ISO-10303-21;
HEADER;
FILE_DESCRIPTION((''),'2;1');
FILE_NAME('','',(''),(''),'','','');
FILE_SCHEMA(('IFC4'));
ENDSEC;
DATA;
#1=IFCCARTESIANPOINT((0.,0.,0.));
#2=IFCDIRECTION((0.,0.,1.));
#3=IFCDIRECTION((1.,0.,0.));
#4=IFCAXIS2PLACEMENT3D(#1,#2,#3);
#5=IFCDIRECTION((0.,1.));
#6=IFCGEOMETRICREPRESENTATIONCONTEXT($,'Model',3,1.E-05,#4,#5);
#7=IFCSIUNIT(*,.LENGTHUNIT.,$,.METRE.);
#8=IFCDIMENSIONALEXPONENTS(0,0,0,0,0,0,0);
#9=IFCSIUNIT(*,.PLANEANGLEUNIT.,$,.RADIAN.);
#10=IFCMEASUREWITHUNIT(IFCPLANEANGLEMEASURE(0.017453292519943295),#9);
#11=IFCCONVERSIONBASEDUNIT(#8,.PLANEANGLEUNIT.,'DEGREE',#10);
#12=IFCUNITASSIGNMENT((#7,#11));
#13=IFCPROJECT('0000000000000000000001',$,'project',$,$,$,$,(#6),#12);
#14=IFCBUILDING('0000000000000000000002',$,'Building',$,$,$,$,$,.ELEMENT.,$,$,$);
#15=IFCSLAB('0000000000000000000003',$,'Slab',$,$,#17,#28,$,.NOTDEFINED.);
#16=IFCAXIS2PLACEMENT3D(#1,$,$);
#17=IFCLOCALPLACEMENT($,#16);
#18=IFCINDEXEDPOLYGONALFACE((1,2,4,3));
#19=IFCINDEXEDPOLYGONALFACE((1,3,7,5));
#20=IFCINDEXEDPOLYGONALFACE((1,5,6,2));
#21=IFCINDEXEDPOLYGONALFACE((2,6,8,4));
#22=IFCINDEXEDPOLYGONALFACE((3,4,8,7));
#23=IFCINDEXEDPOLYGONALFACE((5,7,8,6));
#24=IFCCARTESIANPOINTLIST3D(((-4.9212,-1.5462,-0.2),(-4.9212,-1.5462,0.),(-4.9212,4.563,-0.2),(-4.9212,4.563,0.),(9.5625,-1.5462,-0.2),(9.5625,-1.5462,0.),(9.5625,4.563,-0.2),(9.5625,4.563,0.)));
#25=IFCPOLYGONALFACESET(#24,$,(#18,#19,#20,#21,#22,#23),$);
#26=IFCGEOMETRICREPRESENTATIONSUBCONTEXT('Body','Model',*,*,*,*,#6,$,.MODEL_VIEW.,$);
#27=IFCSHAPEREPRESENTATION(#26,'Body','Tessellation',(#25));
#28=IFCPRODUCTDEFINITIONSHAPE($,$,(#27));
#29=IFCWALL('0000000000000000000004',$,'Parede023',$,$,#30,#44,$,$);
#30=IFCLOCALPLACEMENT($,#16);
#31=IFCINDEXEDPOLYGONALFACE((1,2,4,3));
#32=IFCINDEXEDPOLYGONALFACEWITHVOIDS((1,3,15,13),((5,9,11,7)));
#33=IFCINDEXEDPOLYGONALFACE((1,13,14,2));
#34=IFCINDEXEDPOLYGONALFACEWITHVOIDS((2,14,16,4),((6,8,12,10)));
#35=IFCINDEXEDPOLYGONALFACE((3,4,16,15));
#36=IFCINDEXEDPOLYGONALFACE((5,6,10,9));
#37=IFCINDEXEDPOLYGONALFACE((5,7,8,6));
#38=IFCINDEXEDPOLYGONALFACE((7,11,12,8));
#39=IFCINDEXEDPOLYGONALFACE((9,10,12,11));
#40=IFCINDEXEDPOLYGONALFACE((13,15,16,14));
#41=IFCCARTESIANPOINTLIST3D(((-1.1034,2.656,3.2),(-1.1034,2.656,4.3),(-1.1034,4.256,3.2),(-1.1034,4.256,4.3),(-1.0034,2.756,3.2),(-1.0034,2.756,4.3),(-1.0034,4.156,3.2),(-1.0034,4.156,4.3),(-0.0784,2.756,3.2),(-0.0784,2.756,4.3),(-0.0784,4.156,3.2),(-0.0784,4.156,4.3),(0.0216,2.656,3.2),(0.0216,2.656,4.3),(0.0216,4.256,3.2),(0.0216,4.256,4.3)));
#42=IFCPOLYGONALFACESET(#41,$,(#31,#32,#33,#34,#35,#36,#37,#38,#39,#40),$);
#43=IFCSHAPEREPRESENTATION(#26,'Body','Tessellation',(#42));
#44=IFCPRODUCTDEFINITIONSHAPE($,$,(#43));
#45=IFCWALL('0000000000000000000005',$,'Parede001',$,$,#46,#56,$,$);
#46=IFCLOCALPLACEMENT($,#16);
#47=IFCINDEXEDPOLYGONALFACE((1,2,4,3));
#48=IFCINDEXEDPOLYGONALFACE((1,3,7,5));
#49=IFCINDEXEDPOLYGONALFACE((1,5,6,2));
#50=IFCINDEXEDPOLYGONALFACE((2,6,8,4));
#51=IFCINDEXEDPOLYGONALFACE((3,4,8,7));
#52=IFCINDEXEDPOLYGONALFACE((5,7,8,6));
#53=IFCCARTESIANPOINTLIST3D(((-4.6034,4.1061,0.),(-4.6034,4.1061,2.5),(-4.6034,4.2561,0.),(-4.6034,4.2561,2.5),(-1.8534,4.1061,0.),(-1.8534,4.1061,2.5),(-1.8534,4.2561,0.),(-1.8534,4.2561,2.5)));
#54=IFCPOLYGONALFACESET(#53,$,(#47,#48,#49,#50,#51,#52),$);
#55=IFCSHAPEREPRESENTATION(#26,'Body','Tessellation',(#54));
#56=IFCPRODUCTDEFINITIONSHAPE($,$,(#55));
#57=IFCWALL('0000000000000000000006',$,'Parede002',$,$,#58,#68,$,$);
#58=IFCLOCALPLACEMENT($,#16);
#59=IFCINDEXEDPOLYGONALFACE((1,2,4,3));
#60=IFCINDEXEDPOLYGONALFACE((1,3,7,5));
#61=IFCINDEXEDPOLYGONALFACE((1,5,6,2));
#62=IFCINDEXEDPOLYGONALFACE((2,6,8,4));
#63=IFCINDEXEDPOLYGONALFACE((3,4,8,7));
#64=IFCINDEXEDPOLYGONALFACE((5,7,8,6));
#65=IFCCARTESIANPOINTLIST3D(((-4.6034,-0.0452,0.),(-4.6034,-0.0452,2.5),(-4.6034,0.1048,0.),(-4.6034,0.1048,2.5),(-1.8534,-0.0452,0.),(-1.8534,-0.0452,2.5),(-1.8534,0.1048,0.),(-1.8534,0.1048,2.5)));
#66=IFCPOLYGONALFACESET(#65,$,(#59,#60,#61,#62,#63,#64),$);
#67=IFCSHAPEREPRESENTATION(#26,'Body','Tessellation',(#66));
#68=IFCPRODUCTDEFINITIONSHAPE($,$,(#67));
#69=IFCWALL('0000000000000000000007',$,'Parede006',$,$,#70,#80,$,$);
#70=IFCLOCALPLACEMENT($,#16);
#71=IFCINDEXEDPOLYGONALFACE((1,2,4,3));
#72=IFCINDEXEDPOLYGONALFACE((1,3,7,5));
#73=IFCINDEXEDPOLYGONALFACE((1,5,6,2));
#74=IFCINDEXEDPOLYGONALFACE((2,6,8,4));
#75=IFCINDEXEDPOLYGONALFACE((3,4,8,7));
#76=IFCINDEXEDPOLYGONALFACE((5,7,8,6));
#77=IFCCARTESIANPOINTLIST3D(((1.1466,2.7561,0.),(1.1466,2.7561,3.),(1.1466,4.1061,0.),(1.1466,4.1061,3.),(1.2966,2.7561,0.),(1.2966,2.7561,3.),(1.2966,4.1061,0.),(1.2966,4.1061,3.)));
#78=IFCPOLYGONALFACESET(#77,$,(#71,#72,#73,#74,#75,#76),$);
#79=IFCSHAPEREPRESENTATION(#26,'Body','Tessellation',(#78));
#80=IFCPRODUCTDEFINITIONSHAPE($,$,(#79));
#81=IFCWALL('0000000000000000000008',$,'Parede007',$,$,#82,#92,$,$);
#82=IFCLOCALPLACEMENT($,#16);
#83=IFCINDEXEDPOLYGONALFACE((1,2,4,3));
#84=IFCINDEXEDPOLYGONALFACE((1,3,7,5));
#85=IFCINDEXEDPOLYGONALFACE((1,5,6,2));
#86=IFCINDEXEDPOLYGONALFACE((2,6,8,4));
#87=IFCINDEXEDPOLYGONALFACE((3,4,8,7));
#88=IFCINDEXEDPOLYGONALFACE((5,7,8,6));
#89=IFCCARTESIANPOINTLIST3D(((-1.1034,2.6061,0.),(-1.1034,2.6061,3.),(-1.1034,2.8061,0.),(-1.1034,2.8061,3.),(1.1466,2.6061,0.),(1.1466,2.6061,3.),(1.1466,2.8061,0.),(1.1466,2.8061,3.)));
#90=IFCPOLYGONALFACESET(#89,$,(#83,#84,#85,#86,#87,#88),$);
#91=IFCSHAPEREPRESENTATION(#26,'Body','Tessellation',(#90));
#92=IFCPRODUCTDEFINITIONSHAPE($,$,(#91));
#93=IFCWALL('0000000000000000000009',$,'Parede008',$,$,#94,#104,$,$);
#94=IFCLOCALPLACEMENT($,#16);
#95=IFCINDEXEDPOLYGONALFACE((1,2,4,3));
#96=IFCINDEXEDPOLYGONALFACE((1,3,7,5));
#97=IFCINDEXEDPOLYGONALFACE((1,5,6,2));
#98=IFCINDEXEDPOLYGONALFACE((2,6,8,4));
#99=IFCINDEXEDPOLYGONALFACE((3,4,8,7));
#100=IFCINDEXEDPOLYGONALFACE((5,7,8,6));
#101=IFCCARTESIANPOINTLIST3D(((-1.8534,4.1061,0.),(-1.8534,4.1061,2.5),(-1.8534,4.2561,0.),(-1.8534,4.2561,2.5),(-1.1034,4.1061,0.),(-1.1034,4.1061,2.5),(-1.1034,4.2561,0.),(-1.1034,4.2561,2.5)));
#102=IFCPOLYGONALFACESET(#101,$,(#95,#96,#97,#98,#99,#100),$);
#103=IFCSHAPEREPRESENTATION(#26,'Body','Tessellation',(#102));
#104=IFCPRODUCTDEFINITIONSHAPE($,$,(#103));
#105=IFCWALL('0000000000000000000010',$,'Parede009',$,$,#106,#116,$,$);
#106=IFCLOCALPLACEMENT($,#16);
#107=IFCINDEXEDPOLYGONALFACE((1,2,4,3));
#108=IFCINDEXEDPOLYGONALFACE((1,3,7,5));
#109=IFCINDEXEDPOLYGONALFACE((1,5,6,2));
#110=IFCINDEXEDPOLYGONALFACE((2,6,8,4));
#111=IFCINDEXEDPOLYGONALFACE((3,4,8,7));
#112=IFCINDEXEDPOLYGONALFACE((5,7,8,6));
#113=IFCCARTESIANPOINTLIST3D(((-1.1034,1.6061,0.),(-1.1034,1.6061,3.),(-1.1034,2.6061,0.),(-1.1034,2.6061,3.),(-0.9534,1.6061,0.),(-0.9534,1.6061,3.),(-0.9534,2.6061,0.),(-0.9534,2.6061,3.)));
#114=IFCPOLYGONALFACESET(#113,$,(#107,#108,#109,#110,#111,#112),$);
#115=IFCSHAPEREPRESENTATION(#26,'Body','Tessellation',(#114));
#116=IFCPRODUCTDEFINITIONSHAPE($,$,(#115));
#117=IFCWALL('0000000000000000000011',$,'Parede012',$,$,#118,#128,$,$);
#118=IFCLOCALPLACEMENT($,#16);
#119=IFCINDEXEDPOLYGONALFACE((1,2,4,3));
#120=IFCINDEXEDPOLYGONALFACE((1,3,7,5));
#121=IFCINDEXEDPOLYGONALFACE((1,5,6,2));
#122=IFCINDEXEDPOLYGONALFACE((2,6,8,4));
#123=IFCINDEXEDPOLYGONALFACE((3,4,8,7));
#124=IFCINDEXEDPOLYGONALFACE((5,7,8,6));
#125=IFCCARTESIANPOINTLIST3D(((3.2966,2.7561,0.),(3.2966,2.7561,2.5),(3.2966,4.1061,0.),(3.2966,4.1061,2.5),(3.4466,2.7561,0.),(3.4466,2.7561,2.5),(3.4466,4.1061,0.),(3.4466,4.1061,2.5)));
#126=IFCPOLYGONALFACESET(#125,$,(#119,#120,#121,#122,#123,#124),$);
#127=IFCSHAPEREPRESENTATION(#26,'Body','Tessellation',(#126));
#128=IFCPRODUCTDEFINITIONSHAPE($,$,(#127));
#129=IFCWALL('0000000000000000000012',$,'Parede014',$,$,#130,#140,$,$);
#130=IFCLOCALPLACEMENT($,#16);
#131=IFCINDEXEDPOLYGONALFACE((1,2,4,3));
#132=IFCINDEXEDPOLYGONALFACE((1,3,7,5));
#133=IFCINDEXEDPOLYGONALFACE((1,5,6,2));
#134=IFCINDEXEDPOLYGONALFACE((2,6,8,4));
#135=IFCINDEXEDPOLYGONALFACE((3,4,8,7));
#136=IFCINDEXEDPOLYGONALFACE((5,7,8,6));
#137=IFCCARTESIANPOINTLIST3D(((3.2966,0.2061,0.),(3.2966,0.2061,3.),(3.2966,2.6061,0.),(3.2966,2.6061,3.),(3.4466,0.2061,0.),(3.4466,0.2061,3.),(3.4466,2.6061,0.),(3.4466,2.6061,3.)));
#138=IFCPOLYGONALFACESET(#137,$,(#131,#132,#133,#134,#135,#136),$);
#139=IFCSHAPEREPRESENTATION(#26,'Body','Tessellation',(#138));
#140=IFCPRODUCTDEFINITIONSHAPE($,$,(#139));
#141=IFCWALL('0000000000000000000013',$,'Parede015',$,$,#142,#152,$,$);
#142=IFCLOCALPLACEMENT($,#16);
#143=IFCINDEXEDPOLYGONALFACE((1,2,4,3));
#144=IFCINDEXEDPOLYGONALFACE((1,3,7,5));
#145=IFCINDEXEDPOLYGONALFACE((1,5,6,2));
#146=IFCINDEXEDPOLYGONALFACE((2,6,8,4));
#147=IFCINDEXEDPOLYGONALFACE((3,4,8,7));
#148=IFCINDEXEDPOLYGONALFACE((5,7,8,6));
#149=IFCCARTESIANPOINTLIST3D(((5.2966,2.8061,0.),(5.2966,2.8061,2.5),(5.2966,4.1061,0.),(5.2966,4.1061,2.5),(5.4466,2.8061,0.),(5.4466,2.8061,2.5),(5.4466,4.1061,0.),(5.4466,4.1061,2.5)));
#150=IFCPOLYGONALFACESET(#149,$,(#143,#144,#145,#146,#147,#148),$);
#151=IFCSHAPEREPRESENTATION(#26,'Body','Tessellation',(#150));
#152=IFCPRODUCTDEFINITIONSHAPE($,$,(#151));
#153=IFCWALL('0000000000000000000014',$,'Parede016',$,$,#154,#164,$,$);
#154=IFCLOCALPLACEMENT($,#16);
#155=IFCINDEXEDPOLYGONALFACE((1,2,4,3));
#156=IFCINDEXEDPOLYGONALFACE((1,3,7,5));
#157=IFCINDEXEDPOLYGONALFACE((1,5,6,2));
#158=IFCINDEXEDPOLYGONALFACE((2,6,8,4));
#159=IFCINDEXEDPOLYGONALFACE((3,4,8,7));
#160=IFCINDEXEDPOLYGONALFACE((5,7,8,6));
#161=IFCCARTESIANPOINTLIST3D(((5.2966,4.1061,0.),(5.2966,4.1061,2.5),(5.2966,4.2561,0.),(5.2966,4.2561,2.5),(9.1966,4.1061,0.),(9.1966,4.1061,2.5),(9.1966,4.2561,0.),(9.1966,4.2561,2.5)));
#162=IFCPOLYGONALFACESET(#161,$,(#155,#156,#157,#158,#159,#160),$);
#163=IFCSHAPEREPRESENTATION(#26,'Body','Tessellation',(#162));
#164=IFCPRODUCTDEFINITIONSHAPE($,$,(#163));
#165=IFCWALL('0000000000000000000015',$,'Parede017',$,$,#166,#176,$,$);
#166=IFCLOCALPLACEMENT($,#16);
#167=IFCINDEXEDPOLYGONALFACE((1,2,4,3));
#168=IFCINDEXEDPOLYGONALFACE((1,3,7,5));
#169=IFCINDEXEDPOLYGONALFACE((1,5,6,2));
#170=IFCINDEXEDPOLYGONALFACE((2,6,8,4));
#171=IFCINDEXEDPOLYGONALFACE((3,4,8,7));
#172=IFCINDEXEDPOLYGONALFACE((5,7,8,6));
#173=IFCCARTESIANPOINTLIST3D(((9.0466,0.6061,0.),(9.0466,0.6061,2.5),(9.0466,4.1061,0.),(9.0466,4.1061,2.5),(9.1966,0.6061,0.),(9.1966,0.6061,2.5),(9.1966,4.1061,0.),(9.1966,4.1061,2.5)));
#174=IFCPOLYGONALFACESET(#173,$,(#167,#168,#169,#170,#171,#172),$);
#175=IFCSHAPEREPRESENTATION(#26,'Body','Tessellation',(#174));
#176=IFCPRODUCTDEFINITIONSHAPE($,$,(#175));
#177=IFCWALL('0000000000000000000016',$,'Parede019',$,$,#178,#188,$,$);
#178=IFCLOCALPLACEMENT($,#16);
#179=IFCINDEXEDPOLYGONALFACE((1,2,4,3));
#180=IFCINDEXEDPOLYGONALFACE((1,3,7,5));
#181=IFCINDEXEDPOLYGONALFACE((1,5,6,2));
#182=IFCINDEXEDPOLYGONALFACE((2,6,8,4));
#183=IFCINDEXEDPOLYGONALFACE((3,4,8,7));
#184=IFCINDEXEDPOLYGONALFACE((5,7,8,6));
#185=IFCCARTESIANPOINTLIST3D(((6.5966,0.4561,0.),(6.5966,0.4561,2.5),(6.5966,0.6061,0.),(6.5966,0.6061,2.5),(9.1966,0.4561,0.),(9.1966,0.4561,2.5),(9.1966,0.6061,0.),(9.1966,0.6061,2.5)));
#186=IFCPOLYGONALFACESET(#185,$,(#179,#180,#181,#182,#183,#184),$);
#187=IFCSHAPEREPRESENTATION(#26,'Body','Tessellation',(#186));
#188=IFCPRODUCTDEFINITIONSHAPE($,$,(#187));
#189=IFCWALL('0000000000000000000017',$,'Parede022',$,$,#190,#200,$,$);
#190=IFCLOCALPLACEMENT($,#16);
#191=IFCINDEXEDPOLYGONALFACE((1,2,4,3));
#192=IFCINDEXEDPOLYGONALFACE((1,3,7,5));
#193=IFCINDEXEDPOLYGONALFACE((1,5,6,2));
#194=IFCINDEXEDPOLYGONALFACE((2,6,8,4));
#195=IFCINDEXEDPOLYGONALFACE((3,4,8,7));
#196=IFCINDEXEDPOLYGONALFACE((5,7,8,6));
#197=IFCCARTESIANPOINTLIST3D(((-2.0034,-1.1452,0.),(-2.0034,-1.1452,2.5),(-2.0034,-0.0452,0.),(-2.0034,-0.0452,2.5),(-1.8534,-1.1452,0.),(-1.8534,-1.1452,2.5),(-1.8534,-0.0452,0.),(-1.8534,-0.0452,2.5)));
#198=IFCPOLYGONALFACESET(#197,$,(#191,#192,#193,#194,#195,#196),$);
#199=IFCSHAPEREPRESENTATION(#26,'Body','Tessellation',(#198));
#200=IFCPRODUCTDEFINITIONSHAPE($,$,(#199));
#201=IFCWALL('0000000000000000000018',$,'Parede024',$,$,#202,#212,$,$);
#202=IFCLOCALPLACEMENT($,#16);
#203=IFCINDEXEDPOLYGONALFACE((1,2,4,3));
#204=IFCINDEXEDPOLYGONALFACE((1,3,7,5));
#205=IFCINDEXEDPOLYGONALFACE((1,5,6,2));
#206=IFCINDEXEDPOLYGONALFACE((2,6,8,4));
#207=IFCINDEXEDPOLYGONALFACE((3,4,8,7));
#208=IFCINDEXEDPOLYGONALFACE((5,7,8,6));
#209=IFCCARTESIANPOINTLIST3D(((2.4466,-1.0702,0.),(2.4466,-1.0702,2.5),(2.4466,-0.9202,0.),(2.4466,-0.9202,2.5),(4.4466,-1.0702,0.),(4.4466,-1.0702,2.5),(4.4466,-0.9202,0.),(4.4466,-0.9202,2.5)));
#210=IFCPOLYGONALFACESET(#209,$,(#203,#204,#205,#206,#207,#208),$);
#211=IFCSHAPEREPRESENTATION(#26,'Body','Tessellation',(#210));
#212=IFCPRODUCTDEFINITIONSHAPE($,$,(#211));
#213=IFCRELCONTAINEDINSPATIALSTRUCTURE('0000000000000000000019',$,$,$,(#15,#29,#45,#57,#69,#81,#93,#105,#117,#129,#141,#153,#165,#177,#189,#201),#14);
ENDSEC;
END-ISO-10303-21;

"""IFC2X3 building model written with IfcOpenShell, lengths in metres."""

from ifc_helpers import new_model, entity, si_unit, converted_unit, direction, frame, frame_2d, origin_with_axes, origin_2d_with_axis, place, context, subcontext, project, spatial, polyline, rectangle, outline, extrude, element, save


model = new_model("IFC2X3")

# Units and contexts
model_context = context("Model", 3, precision=1e-05, world=origin_with_axes(), true_north=direction((0.0, 1.0)))
body_context = subcontext(model_context, "Body", "Model", "MODEL_VIEW")
ifc_project = project(units=[si_unit("LENGTHUNIT", "METRE"), converted_unit("PLANEANGLEUNIT", "DEGREE", entity("IfcPlaneAngleMeasure", 0.017453292519943295), si_unit("PLANEANGLEUNIT", "RADIAN"), dimensions=[0, 0, 0, 0, 0, 0, 0])], contexts=[model_context])

# Building
building = spatial("IfcBuilding", Name="Building", CompositionType="ELEMENT")

# Slab
placement = place(None, origin_with_axes())
element("IfcSlab", 1, at=placement, inside=building, Name="Slab", PredefinedType="NOTDEFINED", context=body_context, shape_type="SweptSolid", body=[
    extrude(rectangle(XDim=14.4837, YDim=6.1093, at=origin_2d_with_axis()), frame((2.3207, 1.5084, -0.2), z_axis=(0.0, 0.0, 1.0), x_axis=(1.0, 0.0, 0.0)), (0.0, 0.0, 1.0), 0.2),
])

# Walls
element("IfcWall", 2, at=placement, inside=building, Name="Parede023", context=body_context, shape_type="SweptSolid", body=[
    extrude(outline(polyline([(-0.5625, -0.8), (0.5625, -0.8), (0.5625, 0.8), (-0.5625, 0.8), (-0.5625, -0.8)]), holes=[polyline([(0.4625, -0.7), (0.4625, 0.7), (-0.4625, 0.7), (-0.4625, -0.7), (0.4625, -0.7)])]), frame((-0.5409, 3.456, 3.2), z_axis=(0.0, 0.0, 1.0), x_axis=(1.0, 0.0, 0.0)), (0.0, 0.0, 1.0), 1.1),
])
element("IfcWall", 3, at=placement, inside=building, Name="Parede001", context=body_context, shape_type="SweptSolid", body=[
    extrude(rectangle(XDim=2.75, YDim=0.15, at=origin_2d_with_axis()), frame((-3.2284, 4.1811, 0.0), z_axis=(0.0, 0.0, 1.0), x_axis=(1.0, 0.0, 0.0)), (0.0, 0.0, 1.0), 2.5),
])
element("IfcWall", 4, at=placement, inside=building, Name="Parede002", context=body_context, shape_type="SweptSolid", body=[
    extrude(rectangle(XDim=2.75, YDim=0.15, at=origin_2d_with_axis()), frame((-3.2284, 0.0298, 0.0), z_axis=(0.0, 0.0, 1.0), x_axis=(1.0, 0.0, 0.0)), (0.0, 0.0, 1.0), 2.5),
])
element("IfcWall", 5, at=placement, inside=building, Name="Parede006", context=body_context, shape_type="SweptSolid", body=[
    extrude(rectangle(XDim=1.35, YDim=0.15, at=frame_2d((0.0, 0.0), x_axis=(0.0, -1.0))), frame((1.2216, 3.4311, 0.0), z_axis=(0.0, 0.0, 1.0), x_axis=(1.0, 0.0, 0.0)), (0.0, 0.0, 1.0), 3.0),
])
element("IfcWall", 6, at=placement, inside=building, Name="Parede007", context=body_context, shape_type="SweptSolid", body=[
    extrude(rectangle(XDim=2.25, YDim=0.2, at=origin_2d_with_axis()), frame((0.0216, 2.7061, 0.0), z_axis=(0.0, 0.0, 1.0), x_axis=(1.0, 0.0, 0.0)), (0.0, 0.0, 1.0), 3.0),
])
element("IfcWall", 7, at=placement, inside=building, Name="Parede008", context=body_context, shape_type="SweptSolid", body=[
    extrude(rectangle(XDim=0.75, YDim=0.15, at=origin_2d_with_axis()), frame((-1.4784, 4.1811, 0.0), z_axis=(0.0, 0.0, 1.0), x_axis=(1.0, 0.0, 0.0)), (0.0, 0.0, 1.0), 2.5),
])
element("IfcWall", 8, at=placement, inside=building, Name="Parede009", context=body_context, shape_type="SweptSolid", body=[
    extrude(rectangle(XDim=1.0, YDim=0.15, at=frame_2d((0.0, 0.0), x_axis=(0.0, -1.0))), frame((-1.0284, 2.1061, 0.0), z_axis=(0.0, 0.0, 1.0), x_axis=(1.0, 0.0, 0.0)), (0.0, 0.0, 1.0), 3.0),
])
element("IfcWall", 9, at=placement, inside=building, Name="Parede012", context=body_context, shape_type="SweptSolid", body=[
    extrude(rectangle(XDim=1.35, YDim=0.15, at=frame_2d((0.0, 0.0), x_axis=(0.0, -1.0))), frame((3.3716, 3.4311, 0.0), z_axis=(0.0, 0.0, 1.0), x_axis=(1.0, 0.0, 0.0)), (0.0, 0.0, 1.0), 2.5),
])
element("IfcWall", 10, at=placement, inside=building, Name="Parede014", context=body_context, shape_type="SweptSolid", body=[
    extrude(rectangle(XDim=2.4, YDim=0.15, at=frame_2d((0.0, 0.0), x_axis=(0.0, -1.0))), frame((3.3716, 1.4061, 0.0), z_axis=(0.0, 0.0, 1.0), x_axis=(1.0, 0.0, 0.0)), (0.0, 0.0, 1.0), 3.0),
])
element("IfcWall", 11, at=placement, inside=building, Name="Parede015", context=body_context, shape_type="SweptSolid", body=[
    extrude(rectangle(XDim=1.3, YDim=0.15, at=frame_2d((0.0, 0.0), x_axis=(0.0, 1.0))), frame((5.3716, 3.4561, 0.0), z_axis=(0.0, 0.0, 1.0), x_axis=(1.0, 0.0, 0.0)), (0.0, 0.0, 1.0), 2.5),
])
element("IfcWall", 12, at=placement, inside=building, Name="Parede016", context=body_context, shape_type="SweptSolid", body=[
    extrude(rectangle(XDim=3.9, YDim=0.15, at=origin_2d_with_axis()), frame((7.2466, 4.1811, 0.0), z_axis=(0.0, 0.0, 1.0), x_axis=(1.0, 0.0, 0.0)), (0.0, 0.0, 1.0), 2.5),
])
element("IfcWall", 13, at=placement, inside=building, Name="Parede017", context=body_context, shape_type="SweptSolid", body=[
    extrude(rectangle(XDim=3.5, YDim=0.15, at=frame_2d((0.0, 0.0), x_axis=(0.0, -1.0))), frame((9.1216, 2.3561, 0.0), z_axis=(0.0, 0.0, 1.0), x_axis=(1.0, 0.0, 0.0)), (0.0, 0.0, 1.0), 2.5),
])
element("IfcWall", 14, at=placement, inside=building, Name="Parede019", context=body_context, shape_type="SweptSolid", body=[
    extrude(rectangle(XDim=2.6, YDim=0.15, at=frame_2d((0.0, 0.0), x_axis=(-1.0, 0.0))), frame((7.8966, 0.5311, 0.0), z_axis=(0.0, 0.0, 1.0), x_axis=(1.0, 0.0, 0.0)), (0.0, 0.0, 1.0), 2.5),
])
element("IfcWall", 15, at=placement, inside=building, Name="Parede022", context=body_context, shape_type="SweptSolid", body=[
    extrude(rectangle(XDim=1.1, YDim=0.15, at=frame_2d((0.0, 0.0), x_axis=(0.0, -1.0))), frame((-1.9284, -0.5952, 0.0), z_axis=(0.0, 0.0, 1.0), x_axis=(1.0, 0.0, 0.0)), (0.0, 0.0, 1.0), 2.5),
])
element("IfcWall", 16, at=placement, inside=building, Name="Parede024", context=body_context, shape_type="SweptSolid", body=[
    extrude(rectangle(XDim=2.0, YDim=0.15, at=frame_2d((0.0, 0.0), x_axis=(1.0, 0.0))), frame((3.4466, -0.9952, 0.0), z_axis=(0.0, 0.0, 1.0), x_axis=(1.0, 0.0, 0.0)), (0.0, 0.0, 1.0), 2.5),
])

save(model, "model.ifc")
